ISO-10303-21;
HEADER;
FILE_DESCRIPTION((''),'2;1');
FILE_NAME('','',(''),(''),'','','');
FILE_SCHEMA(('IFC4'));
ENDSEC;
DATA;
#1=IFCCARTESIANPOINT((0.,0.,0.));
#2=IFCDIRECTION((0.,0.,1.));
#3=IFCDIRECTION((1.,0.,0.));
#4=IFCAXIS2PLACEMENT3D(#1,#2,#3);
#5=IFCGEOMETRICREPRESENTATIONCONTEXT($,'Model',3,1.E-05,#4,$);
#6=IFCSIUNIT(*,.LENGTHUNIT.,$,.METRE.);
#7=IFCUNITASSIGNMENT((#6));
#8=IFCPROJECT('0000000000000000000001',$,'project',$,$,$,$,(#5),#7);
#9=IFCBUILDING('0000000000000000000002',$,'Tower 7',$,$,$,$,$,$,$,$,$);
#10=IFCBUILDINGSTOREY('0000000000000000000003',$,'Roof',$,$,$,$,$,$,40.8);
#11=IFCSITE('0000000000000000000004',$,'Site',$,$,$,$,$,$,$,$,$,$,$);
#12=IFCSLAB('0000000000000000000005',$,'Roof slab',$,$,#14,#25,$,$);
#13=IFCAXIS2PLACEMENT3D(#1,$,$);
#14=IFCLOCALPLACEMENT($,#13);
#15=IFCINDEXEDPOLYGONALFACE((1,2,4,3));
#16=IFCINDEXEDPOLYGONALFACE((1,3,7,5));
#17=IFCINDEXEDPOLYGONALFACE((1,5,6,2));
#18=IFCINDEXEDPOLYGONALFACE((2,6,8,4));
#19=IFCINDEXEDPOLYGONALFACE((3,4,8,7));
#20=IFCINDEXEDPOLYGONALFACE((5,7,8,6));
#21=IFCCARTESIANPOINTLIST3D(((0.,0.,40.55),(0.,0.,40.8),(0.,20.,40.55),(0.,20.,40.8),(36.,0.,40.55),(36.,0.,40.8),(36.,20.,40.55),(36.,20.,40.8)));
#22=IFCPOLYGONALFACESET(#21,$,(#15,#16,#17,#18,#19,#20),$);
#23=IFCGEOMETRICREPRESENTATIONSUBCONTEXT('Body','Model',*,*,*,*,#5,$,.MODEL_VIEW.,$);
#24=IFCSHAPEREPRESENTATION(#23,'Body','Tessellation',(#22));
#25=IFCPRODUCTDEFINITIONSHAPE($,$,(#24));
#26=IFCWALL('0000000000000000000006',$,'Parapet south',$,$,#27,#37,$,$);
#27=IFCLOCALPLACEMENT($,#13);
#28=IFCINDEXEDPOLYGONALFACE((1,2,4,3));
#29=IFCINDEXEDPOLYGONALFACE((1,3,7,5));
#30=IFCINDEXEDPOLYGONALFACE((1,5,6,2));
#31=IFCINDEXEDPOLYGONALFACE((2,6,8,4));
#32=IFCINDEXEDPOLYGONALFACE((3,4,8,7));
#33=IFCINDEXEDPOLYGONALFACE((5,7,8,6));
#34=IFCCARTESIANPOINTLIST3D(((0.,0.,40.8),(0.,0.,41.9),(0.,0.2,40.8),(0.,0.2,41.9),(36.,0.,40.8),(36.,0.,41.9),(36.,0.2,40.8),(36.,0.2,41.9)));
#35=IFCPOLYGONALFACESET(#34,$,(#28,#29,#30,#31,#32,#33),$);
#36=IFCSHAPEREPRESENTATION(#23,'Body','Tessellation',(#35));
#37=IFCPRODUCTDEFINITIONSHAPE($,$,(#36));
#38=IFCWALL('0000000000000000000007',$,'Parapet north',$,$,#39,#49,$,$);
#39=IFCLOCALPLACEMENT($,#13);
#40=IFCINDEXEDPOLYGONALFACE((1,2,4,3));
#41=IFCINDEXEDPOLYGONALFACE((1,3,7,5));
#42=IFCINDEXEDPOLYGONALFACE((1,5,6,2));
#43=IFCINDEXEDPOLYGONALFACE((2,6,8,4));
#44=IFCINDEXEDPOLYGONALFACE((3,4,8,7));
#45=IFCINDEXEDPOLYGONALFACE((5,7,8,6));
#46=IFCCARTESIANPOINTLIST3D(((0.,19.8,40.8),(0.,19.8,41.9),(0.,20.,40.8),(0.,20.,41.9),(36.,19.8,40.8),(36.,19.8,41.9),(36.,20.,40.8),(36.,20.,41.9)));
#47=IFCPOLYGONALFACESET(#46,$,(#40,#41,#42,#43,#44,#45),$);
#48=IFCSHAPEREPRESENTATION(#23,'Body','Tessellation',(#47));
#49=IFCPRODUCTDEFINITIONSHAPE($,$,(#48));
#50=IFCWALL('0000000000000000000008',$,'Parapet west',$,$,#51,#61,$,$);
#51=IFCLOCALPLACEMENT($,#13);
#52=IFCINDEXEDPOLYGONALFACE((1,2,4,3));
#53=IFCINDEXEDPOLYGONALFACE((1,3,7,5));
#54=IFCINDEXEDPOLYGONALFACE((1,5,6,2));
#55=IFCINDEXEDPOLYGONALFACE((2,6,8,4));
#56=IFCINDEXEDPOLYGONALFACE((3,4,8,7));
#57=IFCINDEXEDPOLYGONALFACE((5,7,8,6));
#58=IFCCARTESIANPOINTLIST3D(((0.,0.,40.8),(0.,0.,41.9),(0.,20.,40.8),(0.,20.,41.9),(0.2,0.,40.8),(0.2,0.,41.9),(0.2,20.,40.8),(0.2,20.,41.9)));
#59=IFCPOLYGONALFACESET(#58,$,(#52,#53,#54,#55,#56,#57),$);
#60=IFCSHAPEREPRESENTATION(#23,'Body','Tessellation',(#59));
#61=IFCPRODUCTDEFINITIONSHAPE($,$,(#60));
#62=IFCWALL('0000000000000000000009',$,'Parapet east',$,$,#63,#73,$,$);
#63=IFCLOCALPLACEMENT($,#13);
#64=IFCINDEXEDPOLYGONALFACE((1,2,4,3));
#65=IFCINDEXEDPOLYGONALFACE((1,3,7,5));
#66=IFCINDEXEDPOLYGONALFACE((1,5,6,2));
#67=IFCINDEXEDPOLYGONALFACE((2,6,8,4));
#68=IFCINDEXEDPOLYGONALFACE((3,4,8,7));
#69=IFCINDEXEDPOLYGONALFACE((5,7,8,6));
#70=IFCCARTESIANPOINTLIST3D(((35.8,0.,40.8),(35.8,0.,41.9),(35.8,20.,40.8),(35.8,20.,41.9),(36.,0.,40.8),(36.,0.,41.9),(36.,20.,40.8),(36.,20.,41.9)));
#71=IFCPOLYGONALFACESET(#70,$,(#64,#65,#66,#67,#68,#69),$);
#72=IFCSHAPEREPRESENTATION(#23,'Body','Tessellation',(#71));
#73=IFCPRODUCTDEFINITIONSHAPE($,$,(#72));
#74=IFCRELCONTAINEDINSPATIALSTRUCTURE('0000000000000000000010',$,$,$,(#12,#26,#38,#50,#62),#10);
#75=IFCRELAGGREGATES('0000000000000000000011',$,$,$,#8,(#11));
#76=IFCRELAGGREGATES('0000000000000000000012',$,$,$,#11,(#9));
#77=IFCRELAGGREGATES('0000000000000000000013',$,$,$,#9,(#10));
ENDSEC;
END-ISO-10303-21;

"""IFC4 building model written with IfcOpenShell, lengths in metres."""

from ifc_helpers import new_model, si_unit, frame, origin, origin_with_axes, origin_2d, place, context, subcontext, project, spatial, rectangle, extrude, element, save


model = new_model("IFC4")

# Units and contexts
model_context = context("Model", 3, precision=1e-05, world=origin_with_axes())
body_context = subcontext(model_context, "Body", "Model", "MODEL_VIEW")
ifc_project = project(units=[si_unit("LENGTHUNIT", "METRE")], contexts=[model_context])

# Site, building, storey
site = spatial("IfcSite", under=ifc_project, Name="Site")
building = spatial("IfcBuilding", under=site, Name="Tower 7")
storey = spatial("IfcBuildingStorey", under=building, Name="Roof", Elevation=40.8)

# Slab
slab_placement = place(None, frame((18.0, 10.0, 40.55), z_axis=(0.0, 0.0, 1.0), x_axis=(1.0, 0.0, 0.0)))
element("IfcSlab", 1, at=slab_placement, inside=storey, Name="Roof slab", context=body_context, shape_type="SweptSolid", body=[
    extrude(rectangle(XDim=36.0, YDim=20.0, at=origin_2d()), origin(), (0.0, 0.0, 1.0), 0.25),
])

# Walls
wall_1_placement = place(None, frame((18.0, 0.1, 40.8), z_axis=(0.0, 0.0, 1.0), x_axis=(1.0, 0.0, 0.0)))
element("IfcWall", 2, at=wall_1_placement, inside=storey, Name="Parapet south", context=body_context, shape_type="SweptSolid", body=[
    extrude(rectangle(XDim=36.0, YDim=0.2, at=origin_2d()), origin(), (0.0, 0.0, 1.0), 1.1),
])
wall_2_placement = place(None, frame((18.0, 19.9, 40.8), z_axis=(0.0, 0.0, 1.0), x_axis=(1.0, 0.0, 0.0)))
element("IfcWall", 3, at=wall_2_placement, inside=storey, Name="Parapet north", context=body_context, shape_type="SweptSolid", body=[
    extrude(rectangle(XDim=36.0, YDim=0.2, at=origin_2d()), origin(), (0.0, 0.0, 1.0), 1.1),
])
wall_3_placement = place(None, frame((0.1, 10.0, 40.8), z_axis=(0.0, 0.0, 1.0), x_axis=(1.0, 0.0, 0.0)))
element("IfcWall", 4, at=wall_3_placement, inside=storey, Name="Parapet west", context=body_context, shape_type="SweptSolid", body=[
    extrude(rectangle(XDim=0.2, YDim=20.0, at=origin_2d()), origin(), (0.0, 0.0, 1.0), 1.1),
])
wall_4_placement = place(None, frame((35.9, 10.0, 40.8), z_axis=(0.0, 0.0, 1.0), x_axis=(1.0, 0.0, 0.0)))
element("IfcWall", 5, at=wall_4_placement, inside=storey, Name="Parapet east", context=body_context, shape_type="SweptSolid", body=[
    extrude(rectangle(XDim=0.2, YDim=20.0, at=origin_2d()), origin(), (0.0, 0.0, 1.0), 1.1),
])

save(model, "model.ifc")
